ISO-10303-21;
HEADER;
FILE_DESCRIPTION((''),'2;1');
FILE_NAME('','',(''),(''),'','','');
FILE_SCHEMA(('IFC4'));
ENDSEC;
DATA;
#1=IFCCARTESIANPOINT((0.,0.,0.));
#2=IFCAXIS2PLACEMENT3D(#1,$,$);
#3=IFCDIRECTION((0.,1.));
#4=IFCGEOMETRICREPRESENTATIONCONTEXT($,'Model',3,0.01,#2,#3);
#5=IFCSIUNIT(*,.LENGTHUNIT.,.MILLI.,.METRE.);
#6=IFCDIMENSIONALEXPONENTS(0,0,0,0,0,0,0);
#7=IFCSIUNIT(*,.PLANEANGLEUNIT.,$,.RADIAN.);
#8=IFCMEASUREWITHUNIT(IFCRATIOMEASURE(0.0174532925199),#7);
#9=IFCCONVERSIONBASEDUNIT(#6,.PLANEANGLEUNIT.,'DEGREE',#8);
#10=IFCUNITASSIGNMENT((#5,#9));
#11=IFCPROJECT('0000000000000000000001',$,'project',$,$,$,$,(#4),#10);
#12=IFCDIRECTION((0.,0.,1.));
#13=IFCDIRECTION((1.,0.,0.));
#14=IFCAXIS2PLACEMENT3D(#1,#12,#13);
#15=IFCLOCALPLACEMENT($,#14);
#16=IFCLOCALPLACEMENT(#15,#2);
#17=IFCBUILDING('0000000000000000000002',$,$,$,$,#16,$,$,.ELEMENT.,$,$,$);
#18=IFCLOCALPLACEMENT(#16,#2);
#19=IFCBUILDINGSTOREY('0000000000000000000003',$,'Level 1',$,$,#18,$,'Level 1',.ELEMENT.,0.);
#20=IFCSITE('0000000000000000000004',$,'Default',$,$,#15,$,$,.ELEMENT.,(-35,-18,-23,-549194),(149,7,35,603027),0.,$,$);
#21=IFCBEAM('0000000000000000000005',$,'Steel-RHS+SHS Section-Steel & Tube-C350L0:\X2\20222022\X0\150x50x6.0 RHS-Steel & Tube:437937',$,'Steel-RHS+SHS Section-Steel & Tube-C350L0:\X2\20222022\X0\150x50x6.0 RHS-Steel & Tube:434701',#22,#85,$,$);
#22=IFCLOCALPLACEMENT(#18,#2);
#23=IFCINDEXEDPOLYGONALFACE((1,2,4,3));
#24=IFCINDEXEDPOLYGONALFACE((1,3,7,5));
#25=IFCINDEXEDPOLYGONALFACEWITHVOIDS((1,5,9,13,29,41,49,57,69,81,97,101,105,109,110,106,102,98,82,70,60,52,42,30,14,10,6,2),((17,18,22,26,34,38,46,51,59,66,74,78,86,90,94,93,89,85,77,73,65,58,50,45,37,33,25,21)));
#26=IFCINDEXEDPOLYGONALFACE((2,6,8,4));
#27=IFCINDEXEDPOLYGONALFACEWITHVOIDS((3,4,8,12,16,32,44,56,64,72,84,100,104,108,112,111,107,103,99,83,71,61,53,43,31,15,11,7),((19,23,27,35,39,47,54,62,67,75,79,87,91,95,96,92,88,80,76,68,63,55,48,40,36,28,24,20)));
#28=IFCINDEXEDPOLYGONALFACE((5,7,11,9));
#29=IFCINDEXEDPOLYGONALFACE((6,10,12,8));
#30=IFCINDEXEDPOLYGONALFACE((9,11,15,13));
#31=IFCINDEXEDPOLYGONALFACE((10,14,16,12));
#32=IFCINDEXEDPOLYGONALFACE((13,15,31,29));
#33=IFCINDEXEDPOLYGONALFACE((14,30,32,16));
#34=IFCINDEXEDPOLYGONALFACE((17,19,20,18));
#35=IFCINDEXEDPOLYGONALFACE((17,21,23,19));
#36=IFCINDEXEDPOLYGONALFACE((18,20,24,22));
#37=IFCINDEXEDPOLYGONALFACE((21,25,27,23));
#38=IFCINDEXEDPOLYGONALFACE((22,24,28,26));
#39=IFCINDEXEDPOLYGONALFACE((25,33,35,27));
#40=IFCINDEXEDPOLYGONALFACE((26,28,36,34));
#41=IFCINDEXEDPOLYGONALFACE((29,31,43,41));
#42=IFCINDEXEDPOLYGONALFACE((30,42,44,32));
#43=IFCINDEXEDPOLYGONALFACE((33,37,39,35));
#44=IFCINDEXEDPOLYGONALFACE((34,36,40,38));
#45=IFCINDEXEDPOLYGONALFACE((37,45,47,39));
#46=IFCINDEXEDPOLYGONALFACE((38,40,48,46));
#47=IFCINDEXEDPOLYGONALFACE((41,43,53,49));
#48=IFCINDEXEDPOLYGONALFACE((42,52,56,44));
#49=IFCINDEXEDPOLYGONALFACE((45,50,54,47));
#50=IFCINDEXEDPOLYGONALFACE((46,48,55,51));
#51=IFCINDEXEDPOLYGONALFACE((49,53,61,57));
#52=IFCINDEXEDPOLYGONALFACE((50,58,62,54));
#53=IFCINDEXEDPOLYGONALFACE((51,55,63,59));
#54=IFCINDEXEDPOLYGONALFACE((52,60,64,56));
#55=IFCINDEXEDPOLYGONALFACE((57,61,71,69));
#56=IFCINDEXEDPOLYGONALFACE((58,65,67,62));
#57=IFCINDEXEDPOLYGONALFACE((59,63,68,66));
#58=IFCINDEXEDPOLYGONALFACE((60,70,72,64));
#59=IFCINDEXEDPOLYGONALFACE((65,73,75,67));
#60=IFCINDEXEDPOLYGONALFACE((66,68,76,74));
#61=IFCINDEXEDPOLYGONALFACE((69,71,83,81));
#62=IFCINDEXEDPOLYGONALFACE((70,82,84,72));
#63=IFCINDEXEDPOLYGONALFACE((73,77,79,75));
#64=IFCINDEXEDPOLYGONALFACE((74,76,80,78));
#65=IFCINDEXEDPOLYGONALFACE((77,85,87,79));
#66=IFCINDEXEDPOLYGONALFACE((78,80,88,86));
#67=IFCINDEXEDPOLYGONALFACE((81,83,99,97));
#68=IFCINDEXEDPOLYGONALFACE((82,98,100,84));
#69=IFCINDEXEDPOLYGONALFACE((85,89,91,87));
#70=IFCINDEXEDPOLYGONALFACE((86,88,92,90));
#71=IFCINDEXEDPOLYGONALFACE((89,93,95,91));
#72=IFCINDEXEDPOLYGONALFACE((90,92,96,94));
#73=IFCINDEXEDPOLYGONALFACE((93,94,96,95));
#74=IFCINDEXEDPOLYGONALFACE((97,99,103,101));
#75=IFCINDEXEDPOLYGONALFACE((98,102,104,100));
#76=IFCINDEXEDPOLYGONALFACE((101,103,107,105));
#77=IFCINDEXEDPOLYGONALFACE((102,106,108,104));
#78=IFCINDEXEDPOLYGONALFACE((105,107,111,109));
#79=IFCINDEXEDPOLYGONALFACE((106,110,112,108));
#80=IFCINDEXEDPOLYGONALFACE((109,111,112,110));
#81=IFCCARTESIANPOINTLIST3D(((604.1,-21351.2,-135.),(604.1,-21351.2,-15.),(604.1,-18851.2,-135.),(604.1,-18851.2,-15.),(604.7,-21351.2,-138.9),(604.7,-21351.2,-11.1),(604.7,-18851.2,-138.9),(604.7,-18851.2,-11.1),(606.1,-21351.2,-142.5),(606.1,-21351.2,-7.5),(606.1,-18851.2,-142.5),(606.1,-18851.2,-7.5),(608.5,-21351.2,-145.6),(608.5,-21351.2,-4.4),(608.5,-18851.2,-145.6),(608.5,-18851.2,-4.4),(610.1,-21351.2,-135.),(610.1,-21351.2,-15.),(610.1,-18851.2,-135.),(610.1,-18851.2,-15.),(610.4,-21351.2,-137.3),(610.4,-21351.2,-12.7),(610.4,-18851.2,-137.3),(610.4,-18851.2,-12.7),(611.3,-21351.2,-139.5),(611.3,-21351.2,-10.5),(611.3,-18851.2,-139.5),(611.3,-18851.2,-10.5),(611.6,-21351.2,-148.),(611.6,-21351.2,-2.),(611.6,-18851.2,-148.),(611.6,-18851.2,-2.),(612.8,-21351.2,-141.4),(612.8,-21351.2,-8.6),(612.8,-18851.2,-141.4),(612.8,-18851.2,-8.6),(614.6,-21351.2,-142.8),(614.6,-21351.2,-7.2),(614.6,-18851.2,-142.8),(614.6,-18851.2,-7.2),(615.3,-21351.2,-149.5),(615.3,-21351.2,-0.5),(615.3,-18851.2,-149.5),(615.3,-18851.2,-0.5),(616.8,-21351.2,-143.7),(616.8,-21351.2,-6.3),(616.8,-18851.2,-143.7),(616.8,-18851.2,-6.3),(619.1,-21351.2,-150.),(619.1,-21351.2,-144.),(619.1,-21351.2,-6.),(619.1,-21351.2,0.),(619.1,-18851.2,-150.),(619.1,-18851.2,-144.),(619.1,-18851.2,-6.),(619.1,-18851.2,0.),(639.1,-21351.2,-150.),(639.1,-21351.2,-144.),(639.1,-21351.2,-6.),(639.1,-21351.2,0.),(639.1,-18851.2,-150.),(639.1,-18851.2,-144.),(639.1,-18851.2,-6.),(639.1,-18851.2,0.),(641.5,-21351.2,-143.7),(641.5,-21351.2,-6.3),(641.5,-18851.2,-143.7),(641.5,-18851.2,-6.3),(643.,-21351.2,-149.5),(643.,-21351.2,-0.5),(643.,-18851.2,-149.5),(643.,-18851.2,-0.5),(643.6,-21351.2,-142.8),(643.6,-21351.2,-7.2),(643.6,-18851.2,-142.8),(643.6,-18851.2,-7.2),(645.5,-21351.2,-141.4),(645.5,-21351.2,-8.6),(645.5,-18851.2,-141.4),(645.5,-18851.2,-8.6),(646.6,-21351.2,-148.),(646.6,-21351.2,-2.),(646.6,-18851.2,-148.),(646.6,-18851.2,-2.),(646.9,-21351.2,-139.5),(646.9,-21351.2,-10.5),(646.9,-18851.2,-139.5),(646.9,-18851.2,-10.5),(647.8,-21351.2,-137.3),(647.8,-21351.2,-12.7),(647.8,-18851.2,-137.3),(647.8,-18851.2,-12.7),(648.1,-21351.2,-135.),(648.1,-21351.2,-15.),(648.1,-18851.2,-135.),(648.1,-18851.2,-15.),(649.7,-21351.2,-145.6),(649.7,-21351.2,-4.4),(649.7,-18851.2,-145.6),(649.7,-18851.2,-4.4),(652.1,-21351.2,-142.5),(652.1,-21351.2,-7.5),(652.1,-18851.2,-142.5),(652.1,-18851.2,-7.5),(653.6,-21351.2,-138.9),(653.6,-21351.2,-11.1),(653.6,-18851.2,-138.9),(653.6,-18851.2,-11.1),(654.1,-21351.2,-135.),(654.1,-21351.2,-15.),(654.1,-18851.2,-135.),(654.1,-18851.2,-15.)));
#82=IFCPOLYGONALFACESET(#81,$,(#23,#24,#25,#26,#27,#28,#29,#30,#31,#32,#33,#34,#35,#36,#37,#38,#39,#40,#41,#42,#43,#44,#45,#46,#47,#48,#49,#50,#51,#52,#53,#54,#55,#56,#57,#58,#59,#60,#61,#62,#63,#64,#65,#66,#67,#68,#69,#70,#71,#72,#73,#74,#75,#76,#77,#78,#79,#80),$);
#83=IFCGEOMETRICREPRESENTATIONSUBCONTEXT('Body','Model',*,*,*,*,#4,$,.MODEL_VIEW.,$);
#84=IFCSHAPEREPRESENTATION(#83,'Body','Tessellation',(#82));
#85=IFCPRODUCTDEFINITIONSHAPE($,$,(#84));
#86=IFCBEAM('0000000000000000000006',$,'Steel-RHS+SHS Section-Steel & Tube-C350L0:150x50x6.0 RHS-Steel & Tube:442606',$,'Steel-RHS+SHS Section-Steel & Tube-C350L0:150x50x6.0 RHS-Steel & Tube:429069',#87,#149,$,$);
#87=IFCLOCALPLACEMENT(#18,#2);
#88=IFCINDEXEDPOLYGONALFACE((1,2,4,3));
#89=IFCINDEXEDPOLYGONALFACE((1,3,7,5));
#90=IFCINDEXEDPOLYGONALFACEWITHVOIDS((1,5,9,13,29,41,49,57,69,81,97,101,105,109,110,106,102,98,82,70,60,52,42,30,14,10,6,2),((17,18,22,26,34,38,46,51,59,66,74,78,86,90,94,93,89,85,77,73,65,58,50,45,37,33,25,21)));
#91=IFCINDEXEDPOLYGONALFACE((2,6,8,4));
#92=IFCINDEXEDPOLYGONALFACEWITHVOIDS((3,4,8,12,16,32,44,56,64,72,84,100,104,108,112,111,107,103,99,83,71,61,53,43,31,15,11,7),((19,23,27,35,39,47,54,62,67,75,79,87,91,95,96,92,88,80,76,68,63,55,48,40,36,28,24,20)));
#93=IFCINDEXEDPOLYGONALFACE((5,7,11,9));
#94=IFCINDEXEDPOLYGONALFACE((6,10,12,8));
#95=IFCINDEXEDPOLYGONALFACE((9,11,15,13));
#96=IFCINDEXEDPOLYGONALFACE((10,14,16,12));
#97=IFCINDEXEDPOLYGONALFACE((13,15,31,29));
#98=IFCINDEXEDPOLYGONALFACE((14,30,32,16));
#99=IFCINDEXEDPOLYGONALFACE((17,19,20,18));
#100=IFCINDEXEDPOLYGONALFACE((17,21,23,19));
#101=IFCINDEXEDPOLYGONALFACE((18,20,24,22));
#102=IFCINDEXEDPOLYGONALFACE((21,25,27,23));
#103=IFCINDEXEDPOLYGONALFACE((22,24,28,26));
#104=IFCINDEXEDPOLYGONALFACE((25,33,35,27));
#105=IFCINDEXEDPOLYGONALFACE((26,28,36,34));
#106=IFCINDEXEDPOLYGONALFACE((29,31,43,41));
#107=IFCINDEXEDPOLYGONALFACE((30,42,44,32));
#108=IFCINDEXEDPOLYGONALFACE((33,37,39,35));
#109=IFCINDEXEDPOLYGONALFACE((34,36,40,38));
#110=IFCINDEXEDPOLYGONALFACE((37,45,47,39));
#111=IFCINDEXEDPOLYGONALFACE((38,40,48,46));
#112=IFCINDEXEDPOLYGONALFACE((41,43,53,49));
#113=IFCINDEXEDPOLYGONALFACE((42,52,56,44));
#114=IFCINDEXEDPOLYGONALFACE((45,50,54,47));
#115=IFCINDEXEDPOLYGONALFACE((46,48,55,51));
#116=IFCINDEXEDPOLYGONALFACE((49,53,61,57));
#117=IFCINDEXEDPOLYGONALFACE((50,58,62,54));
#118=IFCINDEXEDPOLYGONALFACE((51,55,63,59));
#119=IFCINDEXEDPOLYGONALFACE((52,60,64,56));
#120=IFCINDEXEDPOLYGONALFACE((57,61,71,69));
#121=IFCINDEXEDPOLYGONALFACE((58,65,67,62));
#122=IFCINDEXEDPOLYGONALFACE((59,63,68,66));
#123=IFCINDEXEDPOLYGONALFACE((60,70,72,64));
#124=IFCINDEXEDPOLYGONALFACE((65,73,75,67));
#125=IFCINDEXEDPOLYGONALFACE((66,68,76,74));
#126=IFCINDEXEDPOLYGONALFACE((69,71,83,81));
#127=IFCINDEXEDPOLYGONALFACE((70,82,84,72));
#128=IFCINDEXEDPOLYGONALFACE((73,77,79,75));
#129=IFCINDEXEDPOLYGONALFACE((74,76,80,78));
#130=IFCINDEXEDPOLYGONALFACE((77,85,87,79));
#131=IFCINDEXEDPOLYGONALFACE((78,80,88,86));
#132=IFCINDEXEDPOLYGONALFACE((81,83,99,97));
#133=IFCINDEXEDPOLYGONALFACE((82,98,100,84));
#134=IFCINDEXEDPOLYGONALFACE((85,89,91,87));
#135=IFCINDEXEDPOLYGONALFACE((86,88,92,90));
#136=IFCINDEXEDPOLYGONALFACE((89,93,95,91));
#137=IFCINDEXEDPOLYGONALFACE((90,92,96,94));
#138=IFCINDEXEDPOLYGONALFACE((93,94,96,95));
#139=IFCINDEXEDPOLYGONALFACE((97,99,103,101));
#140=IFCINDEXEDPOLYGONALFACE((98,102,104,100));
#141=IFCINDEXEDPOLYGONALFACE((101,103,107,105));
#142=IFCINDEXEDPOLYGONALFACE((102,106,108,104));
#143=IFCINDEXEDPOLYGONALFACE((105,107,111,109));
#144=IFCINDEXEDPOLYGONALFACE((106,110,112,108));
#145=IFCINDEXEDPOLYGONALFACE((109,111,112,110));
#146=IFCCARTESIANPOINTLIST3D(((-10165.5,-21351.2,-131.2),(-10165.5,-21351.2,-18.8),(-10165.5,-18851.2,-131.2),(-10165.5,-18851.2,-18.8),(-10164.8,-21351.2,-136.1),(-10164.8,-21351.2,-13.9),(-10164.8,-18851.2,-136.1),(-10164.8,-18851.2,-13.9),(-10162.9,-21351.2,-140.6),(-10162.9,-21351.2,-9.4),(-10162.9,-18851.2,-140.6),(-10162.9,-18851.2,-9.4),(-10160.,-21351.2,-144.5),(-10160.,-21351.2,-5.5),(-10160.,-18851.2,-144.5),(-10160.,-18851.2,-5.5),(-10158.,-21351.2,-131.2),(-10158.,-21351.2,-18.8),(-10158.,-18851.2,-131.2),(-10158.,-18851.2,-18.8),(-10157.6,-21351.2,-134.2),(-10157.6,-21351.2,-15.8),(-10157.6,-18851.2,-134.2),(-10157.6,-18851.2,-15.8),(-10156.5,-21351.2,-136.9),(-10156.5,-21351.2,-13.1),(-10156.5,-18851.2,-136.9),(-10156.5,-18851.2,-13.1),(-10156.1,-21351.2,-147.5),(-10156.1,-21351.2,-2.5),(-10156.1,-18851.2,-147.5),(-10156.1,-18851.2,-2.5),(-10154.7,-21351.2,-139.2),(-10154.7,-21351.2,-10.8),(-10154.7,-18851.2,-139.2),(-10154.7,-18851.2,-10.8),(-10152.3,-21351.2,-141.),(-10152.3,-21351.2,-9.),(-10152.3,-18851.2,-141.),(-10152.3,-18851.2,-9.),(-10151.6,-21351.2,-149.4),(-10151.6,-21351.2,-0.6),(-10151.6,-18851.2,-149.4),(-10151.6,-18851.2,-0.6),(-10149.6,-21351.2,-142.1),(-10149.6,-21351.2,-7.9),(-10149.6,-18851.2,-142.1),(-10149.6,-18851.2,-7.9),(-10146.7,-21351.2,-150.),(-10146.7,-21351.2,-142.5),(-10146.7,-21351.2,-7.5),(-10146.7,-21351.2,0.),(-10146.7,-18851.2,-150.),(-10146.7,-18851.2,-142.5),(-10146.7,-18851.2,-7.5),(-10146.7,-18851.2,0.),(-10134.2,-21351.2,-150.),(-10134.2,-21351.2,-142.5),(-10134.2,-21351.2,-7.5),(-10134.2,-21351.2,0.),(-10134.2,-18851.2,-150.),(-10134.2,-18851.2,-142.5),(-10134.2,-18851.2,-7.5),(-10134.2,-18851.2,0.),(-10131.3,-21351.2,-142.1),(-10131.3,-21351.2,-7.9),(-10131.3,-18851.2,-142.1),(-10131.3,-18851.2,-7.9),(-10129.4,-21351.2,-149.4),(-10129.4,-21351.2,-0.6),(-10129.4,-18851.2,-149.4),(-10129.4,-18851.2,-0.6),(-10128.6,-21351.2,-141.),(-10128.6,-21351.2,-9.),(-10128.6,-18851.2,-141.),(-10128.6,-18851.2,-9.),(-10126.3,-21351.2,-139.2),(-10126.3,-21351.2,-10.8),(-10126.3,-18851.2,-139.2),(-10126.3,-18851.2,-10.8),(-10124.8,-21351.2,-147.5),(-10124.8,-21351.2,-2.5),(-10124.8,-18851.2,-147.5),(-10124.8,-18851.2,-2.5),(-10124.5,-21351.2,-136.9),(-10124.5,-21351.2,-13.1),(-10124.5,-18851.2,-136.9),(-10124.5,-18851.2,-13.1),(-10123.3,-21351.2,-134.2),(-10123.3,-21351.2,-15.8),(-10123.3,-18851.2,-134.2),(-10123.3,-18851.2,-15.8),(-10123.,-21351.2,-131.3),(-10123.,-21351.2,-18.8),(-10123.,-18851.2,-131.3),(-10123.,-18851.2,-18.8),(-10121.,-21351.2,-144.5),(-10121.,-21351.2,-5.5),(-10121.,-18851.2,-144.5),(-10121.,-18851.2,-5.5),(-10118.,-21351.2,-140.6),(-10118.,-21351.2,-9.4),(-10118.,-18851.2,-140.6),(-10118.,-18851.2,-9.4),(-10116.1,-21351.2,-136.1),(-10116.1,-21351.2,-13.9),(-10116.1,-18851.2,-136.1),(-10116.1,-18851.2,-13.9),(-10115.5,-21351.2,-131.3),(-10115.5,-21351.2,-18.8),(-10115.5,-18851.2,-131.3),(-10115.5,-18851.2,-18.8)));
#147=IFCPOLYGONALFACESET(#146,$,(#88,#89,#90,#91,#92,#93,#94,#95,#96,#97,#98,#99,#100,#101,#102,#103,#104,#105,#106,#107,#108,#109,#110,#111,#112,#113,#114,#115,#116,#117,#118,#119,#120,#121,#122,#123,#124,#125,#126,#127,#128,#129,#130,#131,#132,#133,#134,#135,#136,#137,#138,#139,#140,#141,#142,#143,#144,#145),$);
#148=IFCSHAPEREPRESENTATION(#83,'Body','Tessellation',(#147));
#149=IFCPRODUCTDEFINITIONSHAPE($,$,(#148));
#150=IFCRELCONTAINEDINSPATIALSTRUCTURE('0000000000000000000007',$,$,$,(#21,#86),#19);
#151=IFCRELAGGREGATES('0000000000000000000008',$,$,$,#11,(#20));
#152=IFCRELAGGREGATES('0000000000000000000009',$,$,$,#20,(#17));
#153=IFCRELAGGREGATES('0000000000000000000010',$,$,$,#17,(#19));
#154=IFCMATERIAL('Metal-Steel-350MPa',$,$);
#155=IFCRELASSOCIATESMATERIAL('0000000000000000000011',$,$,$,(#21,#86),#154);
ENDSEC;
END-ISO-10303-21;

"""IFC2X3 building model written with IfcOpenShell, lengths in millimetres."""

from ifc_helpers import new_model, entity, si_unit, converted_unit, direction, frame, frame_2d, origin, origin_with_axes, place, context, subcontext, project, spatial, polyline, circle_curve, parameter, trimmed, segment, composite_curve, outline, extrude, material, element, save


model = new_model("IFC2X3")

# Units and contexts
model_context = context("Model", 3, precision=0.01, world=origin(), true_north=direction((0.0, 1.0)))
body_context = subcontext(model_context, "Body", "Model", "MODEL_VIEW")
ifc_project = project(units=[si_unit("LENGTHUNIT", "METRE", prefix="MILLI"), converted_unit("PLANEANGLEUNIT", "DEGREE", entity("IfcRatioMeasure", 0.0174532925199), si_unit("PLANEANGLEUNIT", "RADIAN"), dimensions=[0, 0, 0, 0, 0, 0, 0])], contexts=[model_context])

# Site, building, storey
site_placement = place(None, origin_with_axes())
site = spatial("IfcSite", under=ifc_project, at=site_placement, Name="Default", CompositionType="ELEMENT", RefLatitude=(-35, -18, -23, -549194), RefLongitude=(149, 7, 35, 603027), RefElevation=0.0)
building_placement = place(site_placement, origin())
building = spatial("IfcBuilding", under=site, at=building_placement, CompositionType="ELEMENT")
storey_placement = place(building_placement, origin())
storey = spatial("IfcBuildingStorey", under=building, at=storey_placement, Name="Level 1", LongName="Level 1", CompositionType="ELEMENT", Elevation=0.0)

# Beams
ifc_material = material(Name="Metal-Steel-350MPa")
beam_1_placement = place(storey_placement, frame((629.1, -18851.2, 0.0), z_axis=(0.0, 0.0, 1.0), x_axis=(0.0, -1.0, 0.0)))
element("IfcBeam", 1, at=beam_1_placement, inside=storey, material=ifc_material, Name="Steel-RHS+SHS Section-Steel & Tube-C350L0:••150x50x6.0 RHS-Steel & Tube:437937", ObjectType="Steel-RHS+SHS Section-Steel & Tube-C350L0:••150x50x6.0 RHS-Steel & Tube:434701", context=body_context, shape_type="SweptSolid", body=[
    extrude(outline(composite_curve([segment(trimmed(circle_curve(frame_2d((-10.0, -60.0), x_axis=(1.0, 0.0)), 15.0), [parameter(180.0)], [parameter(270.0)], True, "PARAMETER"), True, "CONTINUOUS"), segment(polyline([(-10.0, -75.0), (10.0, -75.0)]), True, "CONTINUOUS"), segment(trimmed(circle_curve(frame_2d((10.0, -60.0), x_axis=(1.0, 0.0)), 15.0), [parameter(270.0)], [parameter(0.0)], True, "PARAMETER"), True, "CONTINUOUS"), segment(polyline([(25.0, -60.0), (25.0, 60.0)]), True, "CONTINUOUS"), segment(trimmed(circle_curve(frame_2d((10.0, 60.0), x_axis=(1.0, 0.0)), 15.0), [parameter(0.0)], [parameter(90.0)], True, "PARAMETER"), True, "CONTINUOUS"), segment(polyline([(10.0, 75.0), (-10.0, 75.0)]), True, "CONTINUOUS"), segment(trimmed(circle_curve(frame_2d((-10.0, 60.0), x_axis=(1.0, 0.0)), 15.0), [parameter(90.0)], [parameter(180.0)], True, "PARAMETER"), True, "CONTINUOUS"), segment(polyline([(-25.0, 60.0), (-25.0, -60.0)]), True, "CONTINUOUS")], self_intersect=False), holes=[composite_curve([segment(polyline([(10.0, -69.0), (-10.0, -69.0)]), True, "CONTINUOUS"), segment(trimmed(circle_curve(frame_2d((-10.0, -60.0), x_axis=(1.0, 0.0)), 9.0), [parameter(180.0)], [parameter(270.0)], True, "PARAMETER"), False, "CONTINUOUS"), segment(polyline([(-19.0, -60.0), (-19.0, 60.0)]), True, "CONTINUOUS"), segment(trimmed(circle_curve(frame_2d((-10.0, 60.0), x_axis=(1.0, 0.0)), 9.0), [parameter(90.0)], [parameter(180.0)], True, "PARAMETER"), False, "CONTINUOUS"), segment(polyline([(-10.0, 69.0), (10.0, 69.0)]), True, "CONTINUOUS"), segment(trimmed(circle_curve(frame_2d((10.0, 60.0), x_axis=(1.0, 0.0)), 9.0), [parameter(360.0)], [parameter(90.0)], True, "PARAMETER"), False, "CONTINUOUS"), segment(polyline([(19.0, 60.0), (19.0, -60.0)]), True, "CONTINUOUS"), segment(trimmed(circle_curve(frame_2d((10.0, -60.0), x_axis=(1.0, 0.0)), 9.0), [parameter(270.0)], [parameter(0.0)], True, "PARAMETER"), False, "CONTINUOUS")], self_intersect=False)]), frame((0.0, 0.0, -75.0), z_axis=(1.0, 0.0, 0.0), x_axis=(0.0, -1.0, 0.0)), (0.0, 0.0, 1.0), 2500.0),
])
beam_2_placement = place(storey_placement, frame((-10140.5, -18851.2, 0.0), z_axis=(0.0, 0.0, 1.0), x_axis=(0.0, -1.0, 0.0)))
element("IfcBeam", 2, at=beam_2_placement, inside=storey, material=ifc_material, Name="Steel-RHS+SHS Section-Steel & Tube-C350L0:150x50x6.0 RHS-Steel & Tube:442606", ObjectType="Steel-RHS+SHS Section-Steel & Tube-C350L0:150x50x6.0 RHS-Steel & Tube:429069", context=body_context, shape_type="SweptSolid", body=[
    extrude(outline(composite_curve([segment(trimmed(circle_curve(frame_2d((-6.2, -56.2), x_axis=(1.0, 0.0)), 18.8), [parameter(180.0)], [parameter(270.0)], True, "PARAMETER"), True, "CONTINUOUS"), segment(polyline([(-6.2, -75.0), (6.2, -75.0)]), True, "CONTINUOUS"), segment(trimmed(circle_curve(frame_2d((6.2, -56.2), x_axis=(1.0, 0.0)), 18.8), [parameter(270.0)], [parameter(0.0)], True, "PARAMETER"), True, "CONTINUOUS"), segment(polyline([(25.0, -56.2), (25.0, 56.2)]), True, "CONTINUOUS"), segment(trimmed(circle_curve(frame_2d((6.2, 56.2), x_axis=(1.0, 0.0)), 18.8), [parameter(0.0)], [parameter(90.0)], True, "PARAMETER"), True, "CONTINUOUS"), segment(polyline([(6.2, 75.0), (-6.2, 75.0)]), True, "CONTINUOUS"), segment(trimmed(circle_curve(frame_2d((-6.2, 56.2), x_axis=(1.0, 0.0)), 18.8), [parameter(90.0)], [parameter(180.0)], True, "PARAMETER"), True, "CONTINUOUS"), segment(polyline([(-25.0, 56.2), (-25.0, -56.2)]), True, "CONTINUOUS")], self_intersect=False), holes=[composite_curve([segment(polyline([(6.2, -67.5), (-6.2, -67.5)]), True, "CONTINUOUS"), segment(trimmed(circle_curve(frame_2d((-6.2, -56.2), x_axis=(1.0, 0.0)), 11.2), [parameter(180.0)], [parameter(270.0)], True, "PARAMETER"), False, "CONTINUOUS"), segment(polyline([(-17.5, -56.2), (-17.5, 56.2)]), True, "CONTINUOUS"), segment(trimmed(circle_curve(frame_2d((-6.2, 56.2), x_axis=(1.0, 0.0)), 11.2), [parameter(90.0)], [parameter(180.0)], True, "PARAMETER"), False, "CONTINUOUS"), segment(polyline([(-6.2, 67.5), (6.2, 67.5)]), True, "CONTINUOUS"), segment(trimmed(circle_curve(frame_2d((6.2, 56.2), x_axis=(1.0, 0.0)), 11.2), [parameter(360.0)], [parameter(90.0)], True, "PARAMETER"), False, "CONTINUOUS"), segment(polyline([(17.5, 56.2), (17.5, -56.2)]), True, "CONTINUOUS"), segment(trimmed(circle_curve(frame_2d((6.2, -56.2), x_axis=(1.0, 0.0)), 11.2), [parameter(270.0)], [parameter(0.0)], True, "PARAMETER"), False, "CONTINUOUS")], self_intersect=False)]), frame((0.0, 0.0, -75.0), z_axis=(1.0, 0.0, 0.0), x_axis=(0.0, -1.0, 0.0)), (0.0, 0.0, 1.0), 2500.0),
])

save(model, "model.ifc")
